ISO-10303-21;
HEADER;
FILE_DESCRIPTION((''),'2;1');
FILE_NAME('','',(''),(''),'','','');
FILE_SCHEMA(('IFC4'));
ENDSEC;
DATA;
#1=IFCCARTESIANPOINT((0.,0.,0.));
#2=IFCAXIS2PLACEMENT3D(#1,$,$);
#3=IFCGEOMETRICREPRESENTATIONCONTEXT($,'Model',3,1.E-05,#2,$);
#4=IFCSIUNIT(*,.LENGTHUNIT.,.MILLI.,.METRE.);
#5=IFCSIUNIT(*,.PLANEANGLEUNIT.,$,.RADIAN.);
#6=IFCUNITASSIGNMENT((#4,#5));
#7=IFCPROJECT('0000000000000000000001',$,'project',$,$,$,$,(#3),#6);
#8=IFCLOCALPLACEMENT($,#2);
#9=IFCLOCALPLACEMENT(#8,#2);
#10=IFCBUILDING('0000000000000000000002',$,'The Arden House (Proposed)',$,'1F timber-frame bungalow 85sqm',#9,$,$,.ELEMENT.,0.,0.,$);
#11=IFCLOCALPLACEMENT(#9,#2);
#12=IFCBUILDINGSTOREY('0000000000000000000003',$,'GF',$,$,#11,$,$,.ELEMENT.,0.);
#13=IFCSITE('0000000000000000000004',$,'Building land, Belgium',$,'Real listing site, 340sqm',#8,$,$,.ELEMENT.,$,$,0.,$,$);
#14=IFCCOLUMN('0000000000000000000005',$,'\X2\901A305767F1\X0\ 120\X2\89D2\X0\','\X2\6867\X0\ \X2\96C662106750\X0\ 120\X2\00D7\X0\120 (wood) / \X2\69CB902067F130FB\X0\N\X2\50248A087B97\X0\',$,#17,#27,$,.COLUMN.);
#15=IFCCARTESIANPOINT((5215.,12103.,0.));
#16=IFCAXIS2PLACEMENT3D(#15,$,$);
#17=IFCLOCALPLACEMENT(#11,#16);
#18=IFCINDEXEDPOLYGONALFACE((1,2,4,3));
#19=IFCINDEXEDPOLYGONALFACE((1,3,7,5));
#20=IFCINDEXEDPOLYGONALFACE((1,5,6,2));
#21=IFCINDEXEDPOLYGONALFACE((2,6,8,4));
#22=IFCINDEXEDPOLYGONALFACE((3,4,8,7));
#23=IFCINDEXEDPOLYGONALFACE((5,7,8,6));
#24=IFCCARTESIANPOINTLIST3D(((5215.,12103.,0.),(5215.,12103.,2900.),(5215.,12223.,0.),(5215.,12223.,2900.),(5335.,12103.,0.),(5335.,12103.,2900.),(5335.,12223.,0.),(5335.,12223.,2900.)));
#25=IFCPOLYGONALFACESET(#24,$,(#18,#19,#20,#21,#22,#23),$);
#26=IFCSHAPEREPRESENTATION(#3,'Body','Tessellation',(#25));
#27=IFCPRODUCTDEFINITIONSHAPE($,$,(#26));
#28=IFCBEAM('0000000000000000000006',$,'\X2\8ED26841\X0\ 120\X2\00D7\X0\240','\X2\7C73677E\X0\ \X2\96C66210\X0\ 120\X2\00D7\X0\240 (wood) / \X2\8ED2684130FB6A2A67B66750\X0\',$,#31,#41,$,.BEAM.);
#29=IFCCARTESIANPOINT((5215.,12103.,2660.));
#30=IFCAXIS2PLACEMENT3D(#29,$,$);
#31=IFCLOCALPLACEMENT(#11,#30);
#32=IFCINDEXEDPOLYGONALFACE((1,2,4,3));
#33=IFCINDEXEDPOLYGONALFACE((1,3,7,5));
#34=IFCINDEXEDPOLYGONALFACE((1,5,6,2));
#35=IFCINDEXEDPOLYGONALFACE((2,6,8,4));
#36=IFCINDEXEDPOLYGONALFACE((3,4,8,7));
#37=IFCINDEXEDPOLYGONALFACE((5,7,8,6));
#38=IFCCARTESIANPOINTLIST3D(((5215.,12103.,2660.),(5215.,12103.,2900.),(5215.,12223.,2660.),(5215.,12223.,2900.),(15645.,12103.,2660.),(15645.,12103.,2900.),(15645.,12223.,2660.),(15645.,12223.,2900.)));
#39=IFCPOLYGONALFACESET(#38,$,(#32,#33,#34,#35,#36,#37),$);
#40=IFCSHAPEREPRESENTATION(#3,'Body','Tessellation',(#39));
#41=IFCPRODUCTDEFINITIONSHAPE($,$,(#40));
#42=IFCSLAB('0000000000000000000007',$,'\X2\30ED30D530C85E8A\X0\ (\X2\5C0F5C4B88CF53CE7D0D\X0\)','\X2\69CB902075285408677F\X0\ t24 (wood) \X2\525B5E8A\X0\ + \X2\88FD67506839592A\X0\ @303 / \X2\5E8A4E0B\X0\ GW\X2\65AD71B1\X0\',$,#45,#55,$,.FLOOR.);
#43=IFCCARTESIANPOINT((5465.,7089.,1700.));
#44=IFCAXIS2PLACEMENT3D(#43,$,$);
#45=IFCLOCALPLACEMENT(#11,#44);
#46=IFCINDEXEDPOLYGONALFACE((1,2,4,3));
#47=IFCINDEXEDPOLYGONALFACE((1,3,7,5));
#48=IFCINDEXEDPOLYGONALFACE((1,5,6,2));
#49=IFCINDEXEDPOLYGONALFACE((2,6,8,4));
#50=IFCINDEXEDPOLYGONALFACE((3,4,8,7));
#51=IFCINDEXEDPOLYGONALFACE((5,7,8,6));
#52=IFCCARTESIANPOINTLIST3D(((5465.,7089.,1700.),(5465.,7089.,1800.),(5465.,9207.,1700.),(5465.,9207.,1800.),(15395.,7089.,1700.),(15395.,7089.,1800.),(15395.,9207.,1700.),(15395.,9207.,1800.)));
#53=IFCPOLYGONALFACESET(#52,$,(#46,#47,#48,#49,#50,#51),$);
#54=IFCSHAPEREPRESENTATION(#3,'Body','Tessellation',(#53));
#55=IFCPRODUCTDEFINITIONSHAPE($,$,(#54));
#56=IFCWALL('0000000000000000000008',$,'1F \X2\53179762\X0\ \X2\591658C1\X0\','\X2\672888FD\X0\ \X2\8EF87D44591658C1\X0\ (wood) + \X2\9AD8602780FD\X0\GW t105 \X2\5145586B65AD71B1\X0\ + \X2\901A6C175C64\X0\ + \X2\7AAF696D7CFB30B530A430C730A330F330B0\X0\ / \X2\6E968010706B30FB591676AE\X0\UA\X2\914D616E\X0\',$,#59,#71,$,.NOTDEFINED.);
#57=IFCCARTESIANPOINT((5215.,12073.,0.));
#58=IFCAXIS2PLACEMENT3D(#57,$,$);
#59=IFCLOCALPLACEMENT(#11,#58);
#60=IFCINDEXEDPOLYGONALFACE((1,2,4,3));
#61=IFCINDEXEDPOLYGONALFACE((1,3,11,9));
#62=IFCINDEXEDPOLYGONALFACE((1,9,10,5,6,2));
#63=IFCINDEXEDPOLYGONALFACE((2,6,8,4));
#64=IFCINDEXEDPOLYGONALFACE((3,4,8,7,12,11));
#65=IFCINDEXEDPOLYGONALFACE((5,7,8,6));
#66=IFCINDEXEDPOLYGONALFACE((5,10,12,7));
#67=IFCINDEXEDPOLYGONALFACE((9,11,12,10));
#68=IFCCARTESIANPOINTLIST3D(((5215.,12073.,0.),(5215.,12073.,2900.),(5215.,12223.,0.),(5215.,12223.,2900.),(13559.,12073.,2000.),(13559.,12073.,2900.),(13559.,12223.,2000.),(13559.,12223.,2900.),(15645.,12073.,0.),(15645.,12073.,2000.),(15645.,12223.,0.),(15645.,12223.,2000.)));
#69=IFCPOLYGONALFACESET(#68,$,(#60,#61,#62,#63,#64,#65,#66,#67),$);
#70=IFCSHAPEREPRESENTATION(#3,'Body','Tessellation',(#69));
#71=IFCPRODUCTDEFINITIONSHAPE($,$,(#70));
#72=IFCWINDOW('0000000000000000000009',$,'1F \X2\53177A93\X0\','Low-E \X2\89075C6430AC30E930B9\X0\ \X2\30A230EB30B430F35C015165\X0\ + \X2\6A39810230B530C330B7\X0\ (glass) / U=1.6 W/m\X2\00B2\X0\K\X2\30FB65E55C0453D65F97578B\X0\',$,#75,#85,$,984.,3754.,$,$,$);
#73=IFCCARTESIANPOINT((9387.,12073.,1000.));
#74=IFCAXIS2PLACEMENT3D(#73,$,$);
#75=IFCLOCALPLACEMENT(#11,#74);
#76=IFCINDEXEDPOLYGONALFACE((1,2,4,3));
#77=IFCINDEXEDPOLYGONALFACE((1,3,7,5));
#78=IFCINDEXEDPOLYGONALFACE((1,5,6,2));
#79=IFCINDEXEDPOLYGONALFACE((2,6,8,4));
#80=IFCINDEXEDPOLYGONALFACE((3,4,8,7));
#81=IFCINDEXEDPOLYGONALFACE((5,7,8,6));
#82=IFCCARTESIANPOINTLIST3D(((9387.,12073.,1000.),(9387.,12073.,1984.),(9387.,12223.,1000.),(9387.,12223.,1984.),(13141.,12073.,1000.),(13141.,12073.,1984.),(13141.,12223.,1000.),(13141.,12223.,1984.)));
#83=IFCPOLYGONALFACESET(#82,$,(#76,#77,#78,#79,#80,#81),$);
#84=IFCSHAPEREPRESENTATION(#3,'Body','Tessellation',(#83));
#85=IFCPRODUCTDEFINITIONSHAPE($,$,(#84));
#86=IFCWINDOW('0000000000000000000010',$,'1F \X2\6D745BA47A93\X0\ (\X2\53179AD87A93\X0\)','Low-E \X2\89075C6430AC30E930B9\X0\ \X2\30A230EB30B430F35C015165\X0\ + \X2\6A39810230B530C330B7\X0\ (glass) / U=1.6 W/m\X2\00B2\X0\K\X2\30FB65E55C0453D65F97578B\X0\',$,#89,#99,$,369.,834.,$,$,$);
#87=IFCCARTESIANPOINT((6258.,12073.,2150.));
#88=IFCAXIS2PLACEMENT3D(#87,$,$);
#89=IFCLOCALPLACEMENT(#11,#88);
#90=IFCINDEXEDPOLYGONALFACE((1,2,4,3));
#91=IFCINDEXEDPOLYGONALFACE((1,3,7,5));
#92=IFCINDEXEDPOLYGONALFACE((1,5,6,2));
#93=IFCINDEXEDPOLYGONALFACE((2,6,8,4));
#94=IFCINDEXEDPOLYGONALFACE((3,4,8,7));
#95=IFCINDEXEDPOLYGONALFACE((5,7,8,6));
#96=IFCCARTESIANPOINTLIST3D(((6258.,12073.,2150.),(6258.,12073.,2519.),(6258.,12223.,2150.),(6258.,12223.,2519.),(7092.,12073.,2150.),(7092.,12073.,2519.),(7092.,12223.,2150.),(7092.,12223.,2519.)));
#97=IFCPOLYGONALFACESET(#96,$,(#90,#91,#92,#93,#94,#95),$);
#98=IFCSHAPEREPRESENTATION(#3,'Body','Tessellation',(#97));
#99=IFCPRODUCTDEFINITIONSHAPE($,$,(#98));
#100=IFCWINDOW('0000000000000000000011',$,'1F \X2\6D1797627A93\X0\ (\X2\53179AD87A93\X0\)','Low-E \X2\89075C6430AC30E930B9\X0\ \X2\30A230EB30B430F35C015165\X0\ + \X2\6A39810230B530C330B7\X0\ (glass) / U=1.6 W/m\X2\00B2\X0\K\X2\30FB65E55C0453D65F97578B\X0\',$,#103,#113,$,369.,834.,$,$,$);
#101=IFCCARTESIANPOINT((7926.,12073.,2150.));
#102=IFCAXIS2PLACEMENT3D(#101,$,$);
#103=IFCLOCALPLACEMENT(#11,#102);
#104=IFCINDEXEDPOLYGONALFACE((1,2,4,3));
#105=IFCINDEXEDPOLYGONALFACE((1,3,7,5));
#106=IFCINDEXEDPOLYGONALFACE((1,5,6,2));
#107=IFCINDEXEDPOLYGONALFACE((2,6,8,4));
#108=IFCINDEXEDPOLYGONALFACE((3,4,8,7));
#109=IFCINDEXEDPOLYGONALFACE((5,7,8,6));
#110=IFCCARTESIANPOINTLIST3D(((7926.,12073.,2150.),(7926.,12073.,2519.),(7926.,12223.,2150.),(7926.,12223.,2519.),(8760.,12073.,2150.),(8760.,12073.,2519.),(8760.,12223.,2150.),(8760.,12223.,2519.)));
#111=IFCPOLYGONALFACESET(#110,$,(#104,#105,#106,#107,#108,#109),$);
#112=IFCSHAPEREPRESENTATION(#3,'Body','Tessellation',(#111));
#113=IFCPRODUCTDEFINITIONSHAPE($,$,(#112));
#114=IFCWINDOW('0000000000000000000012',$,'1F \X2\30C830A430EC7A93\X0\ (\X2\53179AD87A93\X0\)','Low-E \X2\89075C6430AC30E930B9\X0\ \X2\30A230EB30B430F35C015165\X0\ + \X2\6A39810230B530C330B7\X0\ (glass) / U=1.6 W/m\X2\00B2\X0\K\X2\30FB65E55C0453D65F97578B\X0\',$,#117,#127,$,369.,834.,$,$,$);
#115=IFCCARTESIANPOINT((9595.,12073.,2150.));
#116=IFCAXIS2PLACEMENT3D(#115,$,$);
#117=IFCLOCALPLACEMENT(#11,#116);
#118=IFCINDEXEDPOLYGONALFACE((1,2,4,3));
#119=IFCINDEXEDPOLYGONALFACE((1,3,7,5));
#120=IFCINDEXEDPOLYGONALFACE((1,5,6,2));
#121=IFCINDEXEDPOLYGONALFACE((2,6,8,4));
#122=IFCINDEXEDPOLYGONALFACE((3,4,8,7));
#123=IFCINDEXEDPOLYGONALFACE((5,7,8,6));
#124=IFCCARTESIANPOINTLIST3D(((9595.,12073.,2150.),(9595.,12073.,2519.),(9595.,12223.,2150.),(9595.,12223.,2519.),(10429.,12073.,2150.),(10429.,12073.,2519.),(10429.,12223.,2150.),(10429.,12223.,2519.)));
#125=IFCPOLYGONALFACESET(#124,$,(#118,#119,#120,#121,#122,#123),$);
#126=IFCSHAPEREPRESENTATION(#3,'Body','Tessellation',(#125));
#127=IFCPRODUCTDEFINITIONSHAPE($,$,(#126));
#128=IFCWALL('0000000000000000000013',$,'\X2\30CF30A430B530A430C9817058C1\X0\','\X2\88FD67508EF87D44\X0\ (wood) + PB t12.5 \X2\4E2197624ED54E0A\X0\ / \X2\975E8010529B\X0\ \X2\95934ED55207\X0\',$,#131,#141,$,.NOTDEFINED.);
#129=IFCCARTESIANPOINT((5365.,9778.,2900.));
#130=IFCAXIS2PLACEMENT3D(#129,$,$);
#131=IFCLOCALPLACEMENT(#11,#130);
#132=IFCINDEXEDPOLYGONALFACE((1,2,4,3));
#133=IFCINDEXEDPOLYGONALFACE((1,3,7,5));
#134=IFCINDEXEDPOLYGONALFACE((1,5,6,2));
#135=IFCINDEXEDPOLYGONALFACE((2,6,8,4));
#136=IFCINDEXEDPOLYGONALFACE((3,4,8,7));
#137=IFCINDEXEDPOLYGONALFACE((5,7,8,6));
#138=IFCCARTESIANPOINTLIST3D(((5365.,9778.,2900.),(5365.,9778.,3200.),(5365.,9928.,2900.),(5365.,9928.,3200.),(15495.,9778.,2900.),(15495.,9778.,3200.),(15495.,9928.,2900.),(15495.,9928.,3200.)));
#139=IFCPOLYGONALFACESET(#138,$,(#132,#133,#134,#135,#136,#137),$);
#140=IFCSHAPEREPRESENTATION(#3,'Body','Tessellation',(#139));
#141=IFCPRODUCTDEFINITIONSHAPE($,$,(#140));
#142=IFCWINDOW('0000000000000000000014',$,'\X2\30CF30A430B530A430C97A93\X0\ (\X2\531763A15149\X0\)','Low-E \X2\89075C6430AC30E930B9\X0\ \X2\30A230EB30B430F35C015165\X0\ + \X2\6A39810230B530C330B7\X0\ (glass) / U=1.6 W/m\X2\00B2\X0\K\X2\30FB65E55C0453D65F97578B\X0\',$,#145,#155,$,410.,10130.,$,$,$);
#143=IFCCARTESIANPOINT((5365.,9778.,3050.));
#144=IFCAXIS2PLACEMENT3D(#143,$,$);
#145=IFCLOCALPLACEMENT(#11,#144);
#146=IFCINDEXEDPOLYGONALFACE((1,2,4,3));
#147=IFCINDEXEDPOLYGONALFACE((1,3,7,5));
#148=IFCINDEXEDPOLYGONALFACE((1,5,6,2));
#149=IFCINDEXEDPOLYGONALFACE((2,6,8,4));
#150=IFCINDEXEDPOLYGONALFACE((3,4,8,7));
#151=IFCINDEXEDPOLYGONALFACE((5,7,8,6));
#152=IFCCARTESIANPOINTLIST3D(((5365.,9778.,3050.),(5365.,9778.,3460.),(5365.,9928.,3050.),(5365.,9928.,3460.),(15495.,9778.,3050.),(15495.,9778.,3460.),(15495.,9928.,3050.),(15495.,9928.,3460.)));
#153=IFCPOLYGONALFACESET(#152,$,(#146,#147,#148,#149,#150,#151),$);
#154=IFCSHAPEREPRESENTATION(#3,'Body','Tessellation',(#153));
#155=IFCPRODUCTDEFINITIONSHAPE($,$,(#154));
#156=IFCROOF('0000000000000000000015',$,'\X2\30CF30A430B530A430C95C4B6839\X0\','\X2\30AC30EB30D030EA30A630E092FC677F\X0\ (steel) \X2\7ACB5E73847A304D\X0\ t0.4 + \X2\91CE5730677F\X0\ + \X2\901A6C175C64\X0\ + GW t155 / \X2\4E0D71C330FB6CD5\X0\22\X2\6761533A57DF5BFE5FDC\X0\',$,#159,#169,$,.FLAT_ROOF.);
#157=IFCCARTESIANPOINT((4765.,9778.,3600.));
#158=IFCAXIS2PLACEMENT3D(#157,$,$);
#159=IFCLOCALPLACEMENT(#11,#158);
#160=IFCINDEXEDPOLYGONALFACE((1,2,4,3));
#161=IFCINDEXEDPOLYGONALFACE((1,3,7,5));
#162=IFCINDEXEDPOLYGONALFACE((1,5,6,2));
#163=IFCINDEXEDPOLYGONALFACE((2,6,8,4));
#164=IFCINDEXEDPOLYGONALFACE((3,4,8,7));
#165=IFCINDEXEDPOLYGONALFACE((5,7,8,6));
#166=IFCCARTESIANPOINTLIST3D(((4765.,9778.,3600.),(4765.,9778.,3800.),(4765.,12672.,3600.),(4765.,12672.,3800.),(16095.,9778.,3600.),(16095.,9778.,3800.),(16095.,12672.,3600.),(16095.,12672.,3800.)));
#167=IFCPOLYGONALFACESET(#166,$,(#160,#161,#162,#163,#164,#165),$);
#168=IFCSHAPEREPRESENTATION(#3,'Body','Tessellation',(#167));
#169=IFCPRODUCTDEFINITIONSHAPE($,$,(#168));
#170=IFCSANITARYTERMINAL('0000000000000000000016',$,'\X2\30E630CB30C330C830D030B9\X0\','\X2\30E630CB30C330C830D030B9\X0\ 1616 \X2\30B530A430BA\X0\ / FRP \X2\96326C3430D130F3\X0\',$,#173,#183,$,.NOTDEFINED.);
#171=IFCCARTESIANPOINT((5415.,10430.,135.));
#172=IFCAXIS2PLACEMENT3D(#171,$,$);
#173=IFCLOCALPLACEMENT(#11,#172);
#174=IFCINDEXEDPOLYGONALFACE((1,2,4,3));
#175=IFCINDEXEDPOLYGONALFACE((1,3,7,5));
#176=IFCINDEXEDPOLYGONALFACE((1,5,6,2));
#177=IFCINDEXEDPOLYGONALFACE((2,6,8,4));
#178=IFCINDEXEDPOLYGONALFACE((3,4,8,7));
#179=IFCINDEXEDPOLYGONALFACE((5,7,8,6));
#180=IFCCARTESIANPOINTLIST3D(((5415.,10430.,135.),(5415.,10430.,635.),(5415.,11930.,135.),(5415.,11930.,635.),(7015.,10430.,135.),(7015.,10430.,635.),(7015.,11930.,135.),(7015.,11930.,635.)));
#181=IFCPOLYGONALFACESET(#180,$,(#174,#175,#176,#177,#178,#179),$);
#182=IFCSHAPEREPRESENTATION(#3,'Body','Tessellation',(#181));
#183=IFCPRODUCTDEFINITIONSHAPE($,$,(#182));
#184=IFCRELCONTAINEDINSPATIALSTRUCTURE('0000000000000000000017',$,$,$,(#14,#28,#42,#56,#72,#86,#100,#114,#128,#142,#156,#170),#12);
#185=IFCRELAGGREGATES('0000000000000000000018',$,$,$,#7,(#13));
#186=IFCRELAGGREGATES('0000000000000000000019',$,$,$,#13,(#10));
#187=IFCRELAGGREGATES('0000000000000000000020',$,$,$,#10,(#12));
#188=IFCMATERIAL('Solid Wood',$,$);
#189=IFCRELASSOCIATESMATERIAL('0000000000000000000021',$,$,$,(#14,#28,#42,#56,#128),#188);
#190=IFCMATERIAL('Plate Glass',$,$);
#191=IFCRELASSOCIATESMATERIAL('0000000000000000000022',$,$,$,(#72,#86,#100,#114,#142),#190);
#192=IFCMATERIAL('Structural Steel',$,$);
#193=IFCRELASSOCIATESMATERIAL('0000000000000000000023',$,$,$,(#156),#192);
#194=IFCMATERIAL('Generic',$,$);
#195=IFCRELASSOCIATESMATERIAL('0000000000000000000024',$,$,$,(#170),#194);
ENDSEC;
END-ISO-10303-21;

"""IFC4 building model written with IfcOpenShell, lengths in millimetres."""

from ifc_helpers import new_model, si_unit, frame, frame_2d, origin, place, context, project, spatial, rectangle, extrude, material, element, fill, save


model = new_model("IFC4")

# Units and contexts
model_context = context("Model", 3, precision=1e-05, world=origin())
ifc_project = project(units=[si_unit("LENGTHUNIT", "METRE", prefix="MILLI"), si_unit("PLANEANGLEUNIT", "RADIAN")], contexts=[model_context])

# Site, building, storey
site_placement = place(None, origin())
site = spatial("IfcSite", under=ifc_project, at=site_placement, Name="Building land, Belgium", ObjectType="Real listing site, 340sqm", CompositionType="ELEMENT", RefElevation=0.0)
building_placement = place(site_placement, origin())
building = spatial("IfcBuilding", under=site, at=building_placement, Name="The Arden House (Proposed)", ObjectType="1F timber-frame bungalow 85sqm", CompositionType="ELEMENT", ElevationOfRefHeight=0.0, ElevationOfTerrain=0.0)
storey_placement = place(building_placement, origin())
storey = spatial("IfcBuildingStorey", under=building, at=storey_placement, Name="GF", CompositionType="ELEMENT", Elevation=0.0)

# Column
ifc_material_1 = material(Name="Solid Wood")
column_1_placement = place(storey_placement, frame((5215.0, 12103.0, 0.0)))
element("IfcColumn", 1, at=column_1_placement, inside=storey, material=ifc_material_1, Name="通し柱 120角", Description="桧 集成材 120×120 (wood) / 構造柱・N値計算", PredefinedType="COLUMN", context=model_context, shape_type="SweptSolid", body=[
    extrude(rectangle(XDim=120.0, YDim=120.0, at=frame_2d((60.0, 60.0))), frame((5215.0, 12103.0, 0.0)), (0.0, 0.0, 1.0), 2900.0),
])

# Beam
beam_1_placement = place(storey_placement, frame((5215.0, 12103.0, 2660.0)))
element("IfcBeam", 2, at=beam_1_placement, inside=storey, material=ifc_material_1, Name="軒桁 120×240", Description="米松 集成 120×240 (wood) / 軒桁・横架材", PredefinedType="BEAM", context=model_context, shape_type="SweptSolid", body=[
    extrude(rectangle(XDim=10430.0, YDim=120.0, at=frame_2d((5215.0, 60.0))), frame((5215.0, 12103.0, 2660.0)), (0.0, 0.0, 1.0), 240.0),
])

# Slab
slab_placement = place(storey_placement, frame((5465.0, 7089.0, 1700.0)))
element("IfcSlab", 3, at=slab_placement, inside=storey, material=ifc_material_1, Name="ロフト床 (小屋裏収納)", Description="構造用合板 t24 (wood) 剛床 + 製材根太 @303 / 床下 GW断熱", PredefinedType="FLOOR", context=model_context, shape_type="SweptSolid", body=[
    extrude(rectangle(XDim=9930.0, YDim=2118.0, at=frame_2d((4965.0, 1059.0))), frame((5465.0, 7089.0, 1700.0)), (0.0, 0.0, 1.0), 100.0),
])

# Wall, openings, windows
wall_1_placement = place(storey_placement, frame((5215.0, 12073.0, 0.0)))
wall_1 = element("IfcWall", 4, at=wall_1_placement, inside=storey, material=ifc_material_1, Name="1F 北面 外壁", Description="木製 軸組外壁 (wood) + 高性能GW t105 充填断熱 + 通気層 + 窯業系サイディング / 準耐火・外皮UA配慮", PredefinedType="NOTDEFINED", context=model_context, shape_type="SweptSolid", body=[
    extrude(rectangle(XDim=10430.0, YDim=150.0, at=frame_2d((5215.0, 75.0))), frame((5215.0, 12073.0, 0.0)), (0.0, 0.0, 1.0), 2900.0),
])
opening_1_placement = place(storey_placement, frame((9387.0, 12073.0, 1000.0)))
opening_1 = element("IfcOpeningElement", 5, at=opening_1_placement, cuts=wall_1, PredefinedType="NOTDEFINED", context=model_context, shape_type="SweptSolid", body=[
    extrude(rectangle(XDim=3754.0, YDim=150.0, at=frame_2d((1877.0, 75.0))), frame((9387.0, 12073.0, 1000.0)), (0.0, 0.0, 1.0), 984.0),
])
opening_2_placement = place(storey_placement, frame((6258.0, 12073.0, 2150.0)))
opening_2 = element("IfcOpeningElement", 6, at=opening_2_placement, cuts=wall_1, PredefinedType="NOTDEFINED", context=model_context, shape_type="SweptSolid", body=[
    extrude(rectangle(XDim=834.0, YDim=150.0, at=frame_2d((417.0, 75.0))), frame((6258.0, 12073.0, 2150.0)), (0.0, 0.0, 1.0), 369.0),
])
opening_3_placement = place(storey_placement, frame((7926.0, 12073.0, 2150.0)))
opening_3 = element("IfcOpeningElement", 7, at=opening_3_placement, cuts=wall_1, PredefinedType="NOTDEFINED", context=model_context, shape_type="SweptSolid", body=[
    extrude(rectangle(XDim=834.0, YDim=150.0, at=frame_2d((417.0, 75.0))), frame((7926.0, 12073.0, 2150.0)), (0.0, 0.0, 1.0), 369.0),
])
opening_4_placement = place(storey_placement, frame((9595.0, 12073.0, 2150.0)))
opening_4 = element("IfcOpeningElement", 8, at=opening_4_placement, cuts=wall_1, PredefinedType="NOTDEFINED", context=model_context, shape_type="SweptSolid", body=[
    extrude(rectangle(XDim=834.0, YDim=150.0, at=frame_2d((417.0, 75.0))), frame((9595.0, 12073.0, 2150.0)), (0.0, 0.0, 1.0), 369.0),
])
ifc_material_2 = material(Name="Plate Glass")
window_1_placement = place(storey_placement, frame((9387.0, 12073.0, 1000.0)))
window_1 = element("IfcWindow", 9, at=window_1_placement, inside=storey, material=ifc_material_2, Name="1F 北窓", Description="Low-E 複層ガラス アルゴン封入 + 樹脂サッシ (glass) / U=1.6 W/m²K・日射取得型", OverallHeight=984.0, OverallWidth=3754.0, context=model_context, shape_type="SweptSolid", body=[
    extrude(rectangle(XDim=3754.0, YDim=150.0, at=frame_2d((1877.0, 75.0))), frame((9387.0, 12073.0, 1000.0)), (0.0, 0.0, 1.0), 984.0),
])
fill(opening_1, window_1)
window_2_placement = place(storey_placement, frame((6258.0, 12073.0, 2150.0)))
window_2 = element("IfcWindow", 10, at=window_2_placement, inside=storey, material=ifc_material_2, Name="1F 浴室窓 (北高窓)", Description="Low-E 複層ガラス アルゴン封入 + 樹脂サッシ (glass) / U=1.6 W/m²K・日射取得型", OverallHeight=369.0, OverallWidth=834.0, context=model_context, shape_type="SweptSolid", body=[
    extrude(rectangle(XDim=834.0, YDim=150.0, at=frame_2d((417.0, 75.0))), frame((6258.0, 12073.0, 2150.0)), (0.0, 0.0, 1.0), 369.0),
])
fill(opening_2, window_2)
window_3_placement = place(storey_placement, frame((7926.0, 12073.0, 2150.0)))
window_3 = element("IfcWindow", 11, at=window_3_placement, inside=storey, material=ifc_material_2, Name="1F 洗面窓 (北高窓)", Description="Low-E 複層ガラス アルゴン封入 + 樹脂サッシ (glass) / U=1.6 W/m²K・日射取得型", OverallHeight=369.0, OverallWidth=834.0, context=model_context, shape_type="SweptSolid", body=[
    extrude(rectangle(XDim=834.0, YDim=150.0, at=frame_2d((417.0, 75.0))), frame((7926.0, 12073.0, 2150.0)), (0.0, 0.0, 1.0), 369.0),
])
fill(opening_3, window_3)
window_4_placement = place(storey_placement, frame((9595.0, 12073.0, 2150.0)))
window_4 = element("IfcWindow", 12, at=window_4_placement, inside=storey, material=ifc_material_2, Name="1F トイレ窓 (北高窓)", Description="Low-E 複層ガラス アルゴン封入 + 樹脂サッシ (glass) / U=1.6 W/m²K・日射取得型", OverallHeight=369.0, OverallWidth=834.0, context=model_context, shape_type="SweptSolid", body=[
    extrude(rectangle(XDim=834.0, YDim=150.0, at=frame_2d((417.0, 75.0))), frame((9595.0, 12073.0, 2150.0)), (0.0, 0.0, 1.0), 369.0),
])
fill(opening_4, window_4)

# Wall, opening, window
wall_2_placement = place(storey_placement, frame((5365.0, 9778.0, 2900.0)))
wall_2 = element("IfcWall", 13, at=wall_2_placement, inside=storey, material=ifc_material_1, Name="ハイサイド腰壁", Description="製材軸組 (wood) + PB t12.5 両面仕上 / 非耐力 間仕切", PredefinedType="NOTDEFINED", context=model_context, shape_type="SweptSolid", body=[
    extrude(rectangle(XDim=10130.0, YDim=150.0, at=frame_2d((5065.0, 75.0))), frame((5365.0, 9778.0, 2900.0)), (0.0, 0.0, 1.0), 700.0),
])
opening_5_placement = place(storey_placement, frame((5365.0, 9778.0, 3050.0)))
opening_5 = element("IfcOpeningElement", 14, at=opening_5_placement, cuts=wall_2, PredefinedType="NOTDEFINED", context=model_context, shape_type="SweptSolid", body=[
    extrude(rectangle(XDim=10130.0, YDim=150.0, at=frame_2d((5065.0, 75.0))), frame((5365.0, 9778.0, 3050.0)), (0.0, 0.0, 1.0), 410.0),
])
window_5_placement = place(storey_placement, frame((5365.0, 9778.0, 3050.0)))
window_5 = element("IfcWindow", 15, at=window_5_placement, inside=storey, material=ifc_material_2, Name="ハイサイド窓 (北採光)", Description="Low-E 複層ガラス アルゴン封入 + 樹脂サッシ (glass) / U=1.6 W/m²K・日射取得型", OverallHeight=410.0, OverallWidth=10130.0, context=model_context, shape_type="SweptSolid", body=[
    extrude(rectangle(XDim=10130.0, YDim=150.0, at=frame_2d((5065.0, 75.0))), frame((5365.0, 9778.0, 3050.0)), (0.0, 0.0, 1.0), 410.0),
])
fill(opening_5, window_5)

# Roof
ifc_material_3 = material(Name="Structural Steel")
roof_placement = place(storey_placement, frame((4765.0, 9778.0, 3600.0)))
element("IfcRoof", 16, at=roof_placement, inside=storey, material=ifc_material_3, Name="ハイサイド屋根", Description="ガルバリウム鋼板 (steel) 立平葺き t0.4 + 野地板 + 通気層 + GW t155 / 不燃・法22条区域対応", PredefinedType="FLAT_ROOF", context=model_context, shape_type="SweptSolid", body=[
    extrude(rectangle(XDim=11330.0, YDim=2894.0, at=frame_2d((5665.0, 1447.0))), frame((4765.0, 9778.0, 3600.0)), (0.0, 0.0, 1.0), 200.0),
])

# Sanitary terminal
ifc_material_4 = material(Name="Generic")
sanitary_terminal_placement = place(storey_placement, frame((5415.0, 10430.0, 135.0)))
element("IfcSanitaryTerminal", 17, at=sanitary_terminal_placement, inside=storey, material=ifc_material_4, Name="ユニットバス", Description="ユニットバス 1616 サイズ / FRP 防水パン", PredefinedType="NOTDEFINED", context=model_context, shape_type="SweptSolid", body=[
    extrude(rectangle(XDim=1600.0, YDim=1500.0, at=frame_2d((800.0, 750.0))), frame((5415.0, 10430.0, 135.0)), (0.0, 0.0, 1.0), 500.0),
])

save(model, "model.ifc")
